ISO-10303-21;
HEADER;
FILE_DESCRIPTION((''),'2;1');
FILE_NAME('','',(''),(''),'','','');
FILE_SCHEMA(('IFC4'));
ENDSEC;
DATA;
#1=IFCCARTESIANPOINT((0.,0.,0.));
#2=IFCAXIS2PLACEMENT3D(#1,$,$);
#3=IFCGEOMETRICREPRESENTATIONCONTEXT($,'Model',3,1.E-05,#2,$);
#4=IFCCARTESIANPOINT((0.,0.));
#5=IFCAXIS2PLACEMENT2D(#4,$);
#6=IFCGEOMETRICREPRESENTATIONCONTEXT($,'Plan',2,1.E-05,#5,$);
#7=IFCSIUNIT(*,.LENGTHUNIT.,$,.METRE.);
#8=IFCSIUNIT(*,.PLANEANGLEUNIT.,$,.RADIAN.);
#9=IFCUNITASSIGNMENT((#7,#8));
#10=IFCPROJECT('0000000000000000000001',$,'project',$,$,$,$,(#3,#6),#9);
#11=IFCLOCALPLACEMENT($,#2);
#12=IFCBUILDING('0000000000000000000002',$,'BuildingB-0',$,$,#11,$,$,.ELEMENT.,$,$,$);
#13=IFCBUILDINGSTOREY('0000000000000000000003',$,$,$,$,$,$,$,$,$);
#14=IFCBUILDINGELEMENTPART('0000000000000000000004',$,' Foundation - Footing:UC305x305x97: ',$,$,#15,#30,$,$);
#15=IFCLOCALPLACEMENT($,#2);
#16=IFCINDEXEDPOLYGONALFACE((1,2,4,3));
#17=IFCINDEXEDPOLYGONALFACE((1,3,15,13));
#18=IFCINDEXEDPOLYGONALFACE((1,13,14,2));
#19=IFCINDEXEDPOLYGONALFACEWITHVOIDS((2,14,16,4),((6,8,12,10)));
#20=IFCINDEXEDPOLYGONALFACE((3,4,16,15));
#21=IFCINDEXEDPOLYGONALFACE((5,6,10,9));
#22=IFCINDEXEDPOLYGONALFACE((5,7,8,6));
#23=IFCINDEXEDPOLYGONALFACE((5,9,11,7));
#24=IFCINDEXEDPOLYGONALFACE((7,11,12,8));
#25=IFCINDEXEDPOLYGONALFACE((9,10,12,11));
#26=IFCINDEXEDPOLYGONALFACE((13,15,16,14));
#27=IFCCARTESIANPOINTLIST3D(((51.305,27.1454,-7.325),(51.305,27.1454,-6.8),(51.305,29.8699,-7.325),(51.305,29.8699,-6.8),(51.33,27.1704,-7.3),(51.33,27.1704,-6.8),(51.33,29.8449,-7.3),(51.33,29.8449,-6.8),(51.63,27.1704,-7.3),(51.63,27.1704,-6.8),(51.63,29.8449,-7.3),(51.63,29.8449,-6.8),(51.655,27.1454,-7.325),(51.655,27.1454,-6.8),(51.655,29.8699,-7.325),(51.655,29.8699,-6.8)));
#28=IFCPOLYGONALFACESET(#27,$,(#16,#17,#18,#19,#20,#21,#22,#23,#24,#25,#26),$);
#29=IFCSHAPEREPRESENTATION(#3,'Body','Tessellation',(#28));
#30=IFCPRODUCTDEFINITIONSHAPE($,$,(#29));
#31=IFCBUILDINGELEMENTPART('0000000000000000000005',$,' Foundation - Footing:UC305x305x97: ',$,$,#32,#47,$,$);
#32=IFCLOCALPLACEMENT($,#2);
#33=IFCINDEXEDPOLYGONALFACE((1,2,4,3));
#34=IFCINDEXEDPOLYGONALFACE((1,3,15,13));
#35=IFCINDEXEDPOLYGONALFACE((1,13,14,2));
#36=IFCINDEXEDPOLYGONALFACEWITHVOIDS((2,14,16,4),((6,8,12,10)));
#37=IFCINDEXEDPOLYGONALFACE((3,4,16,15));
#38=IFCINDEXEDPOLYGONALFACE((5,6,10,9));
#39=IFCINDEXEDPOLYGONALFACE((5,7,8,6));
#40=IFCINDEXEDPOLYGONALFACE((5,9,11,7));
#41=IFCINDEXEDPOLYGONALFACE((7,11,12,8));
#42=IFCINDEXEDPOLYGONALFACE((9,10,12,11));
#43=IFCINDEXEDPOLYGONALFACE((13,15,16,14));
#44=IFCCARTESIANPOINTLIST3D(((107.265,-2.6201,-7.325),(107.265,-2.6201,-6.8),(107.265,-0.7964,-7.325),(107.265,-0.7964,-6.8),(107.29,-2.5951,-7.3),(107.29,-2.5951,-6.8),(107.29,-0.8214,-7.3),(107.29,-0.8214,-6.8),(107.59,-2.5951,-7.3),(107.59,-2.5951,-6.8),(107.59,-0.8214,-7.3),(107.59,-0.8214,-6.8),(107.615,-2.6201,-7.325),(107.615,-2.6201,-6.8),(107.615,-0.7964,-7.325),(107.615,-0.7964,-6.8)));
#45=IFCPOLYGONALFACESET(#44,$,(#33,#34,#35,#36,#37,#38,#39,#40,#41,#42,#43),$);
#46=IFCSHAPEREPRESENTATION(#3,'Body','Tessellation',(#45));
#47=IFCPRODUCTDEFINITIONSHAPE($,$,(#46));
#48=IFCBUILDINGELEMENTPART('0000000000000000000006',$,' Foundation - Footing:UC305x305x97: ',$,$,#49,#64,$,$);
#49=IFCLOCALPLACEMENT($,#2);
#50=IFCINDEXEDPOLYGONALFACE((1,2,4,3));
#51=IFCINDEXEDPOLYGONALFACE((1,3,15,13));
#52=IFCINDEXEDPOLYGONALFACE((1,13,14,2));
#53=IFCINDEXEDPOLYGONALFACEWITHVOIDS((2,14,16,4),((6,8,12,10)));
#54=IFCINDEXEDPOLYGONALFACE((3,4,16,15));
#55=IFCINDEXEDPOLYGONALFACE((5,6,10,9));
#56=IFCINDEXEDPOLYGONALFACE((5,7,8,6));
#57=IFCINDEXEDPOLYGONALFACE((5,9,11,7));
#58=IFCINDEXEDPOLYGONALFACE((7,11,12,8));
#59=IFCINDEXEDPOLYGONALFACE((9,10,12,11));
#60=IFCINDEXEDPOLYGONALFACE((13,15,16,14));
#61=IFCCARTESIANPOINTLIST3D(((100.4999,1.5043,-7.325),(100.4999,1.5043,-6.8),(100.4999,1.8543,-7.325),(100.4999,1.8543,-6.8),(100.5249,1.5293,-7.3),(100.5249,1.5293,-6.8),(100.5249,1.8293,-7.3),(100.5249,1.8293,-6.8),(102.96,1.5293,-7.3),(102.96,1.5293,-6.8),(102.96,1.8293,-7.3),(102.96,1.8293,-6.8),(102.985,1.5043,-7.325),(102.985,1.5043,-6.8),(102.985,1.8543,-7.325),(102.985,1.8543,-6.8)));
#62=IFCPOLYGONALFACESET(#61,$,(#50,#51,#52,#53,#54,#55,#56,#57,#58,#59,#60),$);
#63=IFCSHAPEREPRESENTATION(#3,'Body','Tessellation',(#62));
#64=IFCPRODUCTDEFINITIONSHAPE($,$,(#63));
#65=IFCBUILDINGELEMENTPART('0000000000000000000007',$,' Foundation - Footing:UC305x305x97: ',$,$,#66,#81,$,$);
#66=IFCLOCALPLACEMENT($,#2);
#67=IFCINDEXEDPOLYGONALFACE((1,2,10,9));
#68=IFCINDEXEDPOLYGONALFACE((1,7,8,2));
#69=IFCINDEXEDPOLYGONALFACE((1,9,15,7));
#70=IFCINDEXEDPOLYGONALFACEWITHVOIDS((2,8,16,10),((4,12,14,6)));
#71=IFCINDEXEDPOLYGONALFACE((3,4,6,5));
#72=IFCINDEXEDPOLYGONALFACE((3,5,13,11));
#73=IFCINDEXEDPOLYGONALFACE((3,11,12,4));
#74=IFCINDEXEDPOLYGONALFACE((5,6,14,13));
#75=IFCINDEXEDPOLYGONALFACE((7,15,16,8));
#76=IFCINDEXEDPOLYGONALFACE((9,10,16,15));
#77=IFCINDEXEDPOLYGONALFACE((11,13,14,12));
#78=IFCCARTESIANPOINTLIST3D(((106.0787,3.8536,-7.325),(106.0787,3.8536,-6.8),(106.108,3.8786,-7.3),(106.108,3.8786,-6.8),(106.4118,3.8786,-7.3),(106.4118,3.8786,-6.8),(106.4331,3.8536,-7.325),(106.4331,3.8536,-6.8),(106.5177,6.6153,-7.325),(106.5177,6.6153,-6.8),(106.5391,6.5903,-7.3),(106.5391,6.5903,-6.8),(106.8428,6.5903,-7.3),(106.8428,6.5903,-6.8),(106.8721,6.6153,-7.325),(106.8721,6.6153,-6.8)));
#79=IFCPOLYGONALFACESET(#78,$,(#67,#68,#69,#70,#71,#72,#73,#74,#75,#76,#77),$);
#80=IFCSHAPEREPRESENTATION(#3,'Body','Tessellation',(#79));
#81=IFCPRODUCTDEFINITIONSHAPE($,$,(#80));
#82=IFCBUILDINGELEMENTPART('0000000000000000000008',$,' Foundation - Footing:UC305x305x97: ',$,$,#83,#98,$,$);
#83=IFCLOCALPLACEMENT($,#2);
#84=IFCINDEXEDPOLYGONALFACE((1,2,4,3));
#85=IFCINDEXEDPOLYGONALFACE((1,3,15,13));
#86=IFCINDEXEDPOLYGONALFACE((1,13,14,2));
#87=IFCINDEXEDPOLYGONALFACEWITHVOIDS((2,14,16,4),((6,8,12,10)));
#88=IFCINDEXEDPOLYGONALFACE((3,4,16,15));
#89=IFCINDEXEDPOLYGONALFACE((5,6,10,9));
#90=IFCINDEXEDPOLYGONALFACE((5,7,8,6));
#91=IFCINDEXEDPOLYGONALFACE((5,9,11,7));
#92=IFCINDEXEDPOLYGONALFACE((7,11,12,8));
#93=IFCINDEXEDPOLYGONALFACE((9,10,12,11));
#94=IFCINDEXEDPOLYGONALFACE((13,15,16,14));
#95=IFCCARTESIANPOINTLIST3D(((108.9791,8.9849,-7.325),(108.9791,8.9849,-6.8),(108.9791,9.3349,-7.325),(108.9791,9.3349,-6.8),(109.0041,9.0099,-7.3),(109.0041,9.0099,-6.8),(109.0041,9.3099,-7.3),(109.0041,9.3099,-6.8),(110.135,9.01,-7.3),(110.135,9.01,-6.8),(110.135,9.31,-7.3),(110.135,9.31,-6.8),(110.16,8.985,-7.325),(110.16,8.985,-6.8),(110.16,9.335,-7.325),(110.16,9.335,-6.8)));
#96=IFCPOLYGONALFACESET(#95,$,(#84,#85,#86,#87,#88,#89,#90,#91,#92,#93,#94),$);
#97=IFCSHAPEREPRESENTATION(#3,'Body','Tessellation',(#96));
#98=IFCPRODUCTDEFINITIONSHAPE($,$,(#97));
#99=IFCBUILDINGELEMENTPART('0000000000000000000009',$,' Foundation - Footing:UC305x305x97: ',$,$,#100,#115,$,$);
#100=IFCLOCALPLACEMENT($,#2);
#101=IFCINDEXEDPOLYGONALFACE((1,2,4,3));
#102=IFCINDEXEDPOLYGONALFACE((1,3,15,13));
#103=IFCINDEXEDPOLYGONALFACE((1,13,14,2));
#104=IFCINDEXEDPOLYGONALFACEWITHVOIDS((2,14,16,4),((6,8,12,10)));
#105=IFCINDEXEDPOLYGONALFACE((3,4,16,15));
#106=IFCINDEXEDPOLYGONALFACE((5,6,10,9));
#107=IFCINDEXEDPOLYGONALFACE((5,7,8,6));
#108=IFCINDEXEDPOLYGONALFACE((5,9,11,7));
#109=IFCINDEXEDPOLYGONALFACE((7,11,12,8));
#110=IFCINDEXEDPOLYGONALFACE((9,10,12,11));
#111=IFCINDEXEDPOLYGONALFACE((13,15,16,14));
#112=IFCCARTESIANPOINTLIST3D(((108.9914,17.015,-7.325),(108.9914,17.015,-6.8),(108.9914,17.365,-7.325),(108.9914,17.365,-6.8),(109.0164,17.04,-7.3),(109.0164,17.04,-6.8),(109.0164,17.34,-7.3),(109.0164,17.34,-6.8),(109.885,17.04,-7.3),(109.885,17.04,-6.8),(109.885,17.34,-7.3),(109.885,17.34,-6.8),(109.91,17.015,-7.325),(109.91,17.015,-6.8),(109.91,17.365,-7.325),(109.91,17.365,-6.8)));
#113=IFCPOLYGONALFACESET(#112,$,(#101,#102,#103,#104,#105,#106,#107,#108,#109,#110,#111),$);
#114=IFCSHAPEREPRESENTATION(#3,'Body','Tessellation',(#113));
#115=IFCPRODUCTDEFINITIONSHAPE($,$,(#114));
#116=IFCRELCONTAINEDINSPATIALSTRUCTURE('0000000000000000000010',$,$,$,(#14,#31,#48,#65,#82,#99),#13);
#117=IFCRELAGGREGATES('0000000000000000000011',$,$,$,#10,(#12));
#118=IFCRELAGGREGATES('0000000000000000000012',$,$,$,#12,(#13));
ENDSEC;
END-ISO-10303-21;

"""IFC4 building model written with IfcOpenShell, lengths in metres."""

from ifc_helpers import new_model, si_unit, origin, origin_2d, place, context, project, spatial, polyline, outline, extrude, element, save


model = new_model("IFC4")

# Units and contexts
model_context = context("Model", 3, precision=1e-05, world=origin())
plan_context = context("Plan", 2, precision=1e-05, world=origin_2d())
ifc_project = project(units=[si_unit("LENGTHUNIT", "METRE"), si_unit("PLANEANGLEUNIT", "RADIAN")], contexts=[model_context, plan_context])

# Building, storey
building_placement = place(None, origin())
building = spatial("IfcBuilding", under=ifc_project, at=building_placement, Name="BuildingB-0", CompositionType="ELEMENT")
storey = spatial("IfcBuildingStorey", under=building)

# Building element parts, openings
building_element_part_1 = element("IfcBuildingElementPart", 1, inside=storey, Name=" Foundation - Footing:UC305x305x97: ", context=model_context, shape_type="SweptSolid", body=[
    extrude(outline(polyline([(51.305, 27.1454, -7.325), (51.655, 27.1454, -7.325), (51.655, 29.8699, -7.325), (51.305, 29.8699, -7.325), (51.305, 27.1454, -7.325)])), None, (0.0, 0.0, 1.0), 0.525),
])
element("IfcOpeningElement", 2, inside=storey, cuts=building_element_part_1, context=model_context, shape_type="SweptSolid", body=[
    extrude(outline(polyline([(51.33, 27.1704, -7.3), (51.63, 27.1704, -7.3), (51.63, 29.8449, -7.3), (51.33, 29.8449, -7.3), (51.33, 27.1704, -7.3)])), None, (0.0, 0.0, 1.0), 0.5),
])
building_element_part_2 = element("IfcBuildingElementPart", 3, inside=storey, Name=" Foundation - Footing:UC305x305x97: ", context=model_context, shape_type="SweptSolid", body=[
    extrude(outline(polyline([(107.615, -2.6201, -7.325), (107.265, -2.6201, -7.325), (107.265, -0.7964, -7.325), (107.615, -0.7964, -7.325), (107.615, -2.6201, -7.325)])), None, (0.0, 0.0, 1.0), 0.525),
])
element("IfcOpeningElement", 4, inside=storey, cuts=building_element_part_2, context=model_context, shape_type="SweptSolid", body=[
    extrude(outline(polyline([(107.59, -2.5951, -7.3), (107.29, -2.5951, -7.3), (107.29, -0.8214, -7.3), (107.59, -0.8214, -7.3), (107.59, -2.5951, -7.3)])), None, (0.0, 0.0, 1.0), 0.5),
])
building_element_part_3 = element("IfcBuildingElementPart", 5, inside=storey, Name=" Foundation - Footing:UC305x305x97: ", context=model_context, shape_type="SweptSolid", body=[
    extrude(outline(polyline([(102.985, 1.5043, -7.325), (102.985, 1.8543, -7.325), (100.4999, 1.8543, -7.325), (100.4999, 1.5043, -7.325), (102.985, 1.5043, -7.325)])), None, (0.0, 0.0, 1.0), 0.525),
])
element("IfcOpeningElement", 6, inside=storey, cuts=building_element_part_3, context=model_context, shape_type="SweptSolid", body=[
    extrude(outline(polyline([(102.96, 1.5293, -7.3), (102.96, 1.8293, -7.3), (100.5249, 1.8293, -7.3), (100.5249, 1.5293, -7.3), (102.96, 1.5293, -7.3)])), None, (0.0, 0.0, 1.0), 0.5),
])
building_element_part_4 = element("IfcBuildingElementPart", 7, inside=storey, Name=" Foundation - Footing:UC305x305x97: ", context=model_context, shape_type="SweptSolid", body=[
    extrude(outline(polyline([(106.4331, 3.8536, -7.325), (106.8721, 6.6153, -7.325), (106.5177, 6.6153, -7.325), (106.0787, 3.8536, -7.325), (106.4331, 3.8536, -7.325)])), None, (0.0, 0.0, 1.0), 0.525),
])
element("IfcOpeningElement", 8, inside=storey, cuts=building_element_part_4, context=model_context, shape_type="SweptSolid", body=[
    extrude(outline(polyline([(106.4118, 3.8786, -7.3), (106.8428, 6.5903, -7.3), (106.5391, 6.5903, -7.3), (106.108, 3.8786, -7.3), (106.4118, 3.8786, -7.3)])), None, (0.0, 0.0, 1.0), 0.5),
])
building_element_part_5 = element("IfcBuildingElementPart", 9, inside=storey, Name=" Foundation - Footing:UC305x305x97: ", context=model_context, shape_type="SweptSolid", body=[
    extrude(outline(polyline([(110.16, 8.985, -7.325), (110.16, 9.335, -7.325), (108.9791, 9.3349, -7.325), (108.9791, 8.9849, -7.325), (110.16, 8.985, -7.325)])), None, (0.0, 0.0, 1.0), 0.525),
])
element("IfcOpeningElement", 10, inside=storey, cuts=building_element_part_5, context=model_context, shape_type="SweptSolid", body=[
    extrude(outline(polyline([(110.135, 9.01, -7.3), (110.135, 9.31, -7.3), (109.0041, 9.3099, -7.3), (109.0041, 9.0099, -7.3), (110.135, 9.01, -7.3)])), None, (0.0, 0.0, 1.0), 0.5),
])
building_element_part_6 = element("IfcBuildingElementPart", 11, inside=storey, Name=" Foundation - Footing:UC305x305x97: ", context=model_context, shape_type="SweptSolid", body=[
    extrude(outline(polyline([(109.91, 17.015, -7.325), (109.91, 17.365, -7.325), (108.9914, 17.365, -7.325), (108.9914, 17.015, -7.325), (109.91, 17.015, -7.325)])), None, (0.0, 0.0, 1.0), 0.525),
])
element("IfcOpeningElement", 12, inside=storey, cuts=building_element_part_6, context=model_context, shape_type="SweptSolid", body=[
    extrude(outline(polyline([(109.885, 17.04, -7.3), (109.885, 17.34, -7.3), (109.0164, 17.34, -7.3), (109.0164, 17.04, -7.3), (109.885, 17.04, -7.3)])), None, (0.0, 0.0, 1.0), 0.5),
])

save(model, "model.ifc")
